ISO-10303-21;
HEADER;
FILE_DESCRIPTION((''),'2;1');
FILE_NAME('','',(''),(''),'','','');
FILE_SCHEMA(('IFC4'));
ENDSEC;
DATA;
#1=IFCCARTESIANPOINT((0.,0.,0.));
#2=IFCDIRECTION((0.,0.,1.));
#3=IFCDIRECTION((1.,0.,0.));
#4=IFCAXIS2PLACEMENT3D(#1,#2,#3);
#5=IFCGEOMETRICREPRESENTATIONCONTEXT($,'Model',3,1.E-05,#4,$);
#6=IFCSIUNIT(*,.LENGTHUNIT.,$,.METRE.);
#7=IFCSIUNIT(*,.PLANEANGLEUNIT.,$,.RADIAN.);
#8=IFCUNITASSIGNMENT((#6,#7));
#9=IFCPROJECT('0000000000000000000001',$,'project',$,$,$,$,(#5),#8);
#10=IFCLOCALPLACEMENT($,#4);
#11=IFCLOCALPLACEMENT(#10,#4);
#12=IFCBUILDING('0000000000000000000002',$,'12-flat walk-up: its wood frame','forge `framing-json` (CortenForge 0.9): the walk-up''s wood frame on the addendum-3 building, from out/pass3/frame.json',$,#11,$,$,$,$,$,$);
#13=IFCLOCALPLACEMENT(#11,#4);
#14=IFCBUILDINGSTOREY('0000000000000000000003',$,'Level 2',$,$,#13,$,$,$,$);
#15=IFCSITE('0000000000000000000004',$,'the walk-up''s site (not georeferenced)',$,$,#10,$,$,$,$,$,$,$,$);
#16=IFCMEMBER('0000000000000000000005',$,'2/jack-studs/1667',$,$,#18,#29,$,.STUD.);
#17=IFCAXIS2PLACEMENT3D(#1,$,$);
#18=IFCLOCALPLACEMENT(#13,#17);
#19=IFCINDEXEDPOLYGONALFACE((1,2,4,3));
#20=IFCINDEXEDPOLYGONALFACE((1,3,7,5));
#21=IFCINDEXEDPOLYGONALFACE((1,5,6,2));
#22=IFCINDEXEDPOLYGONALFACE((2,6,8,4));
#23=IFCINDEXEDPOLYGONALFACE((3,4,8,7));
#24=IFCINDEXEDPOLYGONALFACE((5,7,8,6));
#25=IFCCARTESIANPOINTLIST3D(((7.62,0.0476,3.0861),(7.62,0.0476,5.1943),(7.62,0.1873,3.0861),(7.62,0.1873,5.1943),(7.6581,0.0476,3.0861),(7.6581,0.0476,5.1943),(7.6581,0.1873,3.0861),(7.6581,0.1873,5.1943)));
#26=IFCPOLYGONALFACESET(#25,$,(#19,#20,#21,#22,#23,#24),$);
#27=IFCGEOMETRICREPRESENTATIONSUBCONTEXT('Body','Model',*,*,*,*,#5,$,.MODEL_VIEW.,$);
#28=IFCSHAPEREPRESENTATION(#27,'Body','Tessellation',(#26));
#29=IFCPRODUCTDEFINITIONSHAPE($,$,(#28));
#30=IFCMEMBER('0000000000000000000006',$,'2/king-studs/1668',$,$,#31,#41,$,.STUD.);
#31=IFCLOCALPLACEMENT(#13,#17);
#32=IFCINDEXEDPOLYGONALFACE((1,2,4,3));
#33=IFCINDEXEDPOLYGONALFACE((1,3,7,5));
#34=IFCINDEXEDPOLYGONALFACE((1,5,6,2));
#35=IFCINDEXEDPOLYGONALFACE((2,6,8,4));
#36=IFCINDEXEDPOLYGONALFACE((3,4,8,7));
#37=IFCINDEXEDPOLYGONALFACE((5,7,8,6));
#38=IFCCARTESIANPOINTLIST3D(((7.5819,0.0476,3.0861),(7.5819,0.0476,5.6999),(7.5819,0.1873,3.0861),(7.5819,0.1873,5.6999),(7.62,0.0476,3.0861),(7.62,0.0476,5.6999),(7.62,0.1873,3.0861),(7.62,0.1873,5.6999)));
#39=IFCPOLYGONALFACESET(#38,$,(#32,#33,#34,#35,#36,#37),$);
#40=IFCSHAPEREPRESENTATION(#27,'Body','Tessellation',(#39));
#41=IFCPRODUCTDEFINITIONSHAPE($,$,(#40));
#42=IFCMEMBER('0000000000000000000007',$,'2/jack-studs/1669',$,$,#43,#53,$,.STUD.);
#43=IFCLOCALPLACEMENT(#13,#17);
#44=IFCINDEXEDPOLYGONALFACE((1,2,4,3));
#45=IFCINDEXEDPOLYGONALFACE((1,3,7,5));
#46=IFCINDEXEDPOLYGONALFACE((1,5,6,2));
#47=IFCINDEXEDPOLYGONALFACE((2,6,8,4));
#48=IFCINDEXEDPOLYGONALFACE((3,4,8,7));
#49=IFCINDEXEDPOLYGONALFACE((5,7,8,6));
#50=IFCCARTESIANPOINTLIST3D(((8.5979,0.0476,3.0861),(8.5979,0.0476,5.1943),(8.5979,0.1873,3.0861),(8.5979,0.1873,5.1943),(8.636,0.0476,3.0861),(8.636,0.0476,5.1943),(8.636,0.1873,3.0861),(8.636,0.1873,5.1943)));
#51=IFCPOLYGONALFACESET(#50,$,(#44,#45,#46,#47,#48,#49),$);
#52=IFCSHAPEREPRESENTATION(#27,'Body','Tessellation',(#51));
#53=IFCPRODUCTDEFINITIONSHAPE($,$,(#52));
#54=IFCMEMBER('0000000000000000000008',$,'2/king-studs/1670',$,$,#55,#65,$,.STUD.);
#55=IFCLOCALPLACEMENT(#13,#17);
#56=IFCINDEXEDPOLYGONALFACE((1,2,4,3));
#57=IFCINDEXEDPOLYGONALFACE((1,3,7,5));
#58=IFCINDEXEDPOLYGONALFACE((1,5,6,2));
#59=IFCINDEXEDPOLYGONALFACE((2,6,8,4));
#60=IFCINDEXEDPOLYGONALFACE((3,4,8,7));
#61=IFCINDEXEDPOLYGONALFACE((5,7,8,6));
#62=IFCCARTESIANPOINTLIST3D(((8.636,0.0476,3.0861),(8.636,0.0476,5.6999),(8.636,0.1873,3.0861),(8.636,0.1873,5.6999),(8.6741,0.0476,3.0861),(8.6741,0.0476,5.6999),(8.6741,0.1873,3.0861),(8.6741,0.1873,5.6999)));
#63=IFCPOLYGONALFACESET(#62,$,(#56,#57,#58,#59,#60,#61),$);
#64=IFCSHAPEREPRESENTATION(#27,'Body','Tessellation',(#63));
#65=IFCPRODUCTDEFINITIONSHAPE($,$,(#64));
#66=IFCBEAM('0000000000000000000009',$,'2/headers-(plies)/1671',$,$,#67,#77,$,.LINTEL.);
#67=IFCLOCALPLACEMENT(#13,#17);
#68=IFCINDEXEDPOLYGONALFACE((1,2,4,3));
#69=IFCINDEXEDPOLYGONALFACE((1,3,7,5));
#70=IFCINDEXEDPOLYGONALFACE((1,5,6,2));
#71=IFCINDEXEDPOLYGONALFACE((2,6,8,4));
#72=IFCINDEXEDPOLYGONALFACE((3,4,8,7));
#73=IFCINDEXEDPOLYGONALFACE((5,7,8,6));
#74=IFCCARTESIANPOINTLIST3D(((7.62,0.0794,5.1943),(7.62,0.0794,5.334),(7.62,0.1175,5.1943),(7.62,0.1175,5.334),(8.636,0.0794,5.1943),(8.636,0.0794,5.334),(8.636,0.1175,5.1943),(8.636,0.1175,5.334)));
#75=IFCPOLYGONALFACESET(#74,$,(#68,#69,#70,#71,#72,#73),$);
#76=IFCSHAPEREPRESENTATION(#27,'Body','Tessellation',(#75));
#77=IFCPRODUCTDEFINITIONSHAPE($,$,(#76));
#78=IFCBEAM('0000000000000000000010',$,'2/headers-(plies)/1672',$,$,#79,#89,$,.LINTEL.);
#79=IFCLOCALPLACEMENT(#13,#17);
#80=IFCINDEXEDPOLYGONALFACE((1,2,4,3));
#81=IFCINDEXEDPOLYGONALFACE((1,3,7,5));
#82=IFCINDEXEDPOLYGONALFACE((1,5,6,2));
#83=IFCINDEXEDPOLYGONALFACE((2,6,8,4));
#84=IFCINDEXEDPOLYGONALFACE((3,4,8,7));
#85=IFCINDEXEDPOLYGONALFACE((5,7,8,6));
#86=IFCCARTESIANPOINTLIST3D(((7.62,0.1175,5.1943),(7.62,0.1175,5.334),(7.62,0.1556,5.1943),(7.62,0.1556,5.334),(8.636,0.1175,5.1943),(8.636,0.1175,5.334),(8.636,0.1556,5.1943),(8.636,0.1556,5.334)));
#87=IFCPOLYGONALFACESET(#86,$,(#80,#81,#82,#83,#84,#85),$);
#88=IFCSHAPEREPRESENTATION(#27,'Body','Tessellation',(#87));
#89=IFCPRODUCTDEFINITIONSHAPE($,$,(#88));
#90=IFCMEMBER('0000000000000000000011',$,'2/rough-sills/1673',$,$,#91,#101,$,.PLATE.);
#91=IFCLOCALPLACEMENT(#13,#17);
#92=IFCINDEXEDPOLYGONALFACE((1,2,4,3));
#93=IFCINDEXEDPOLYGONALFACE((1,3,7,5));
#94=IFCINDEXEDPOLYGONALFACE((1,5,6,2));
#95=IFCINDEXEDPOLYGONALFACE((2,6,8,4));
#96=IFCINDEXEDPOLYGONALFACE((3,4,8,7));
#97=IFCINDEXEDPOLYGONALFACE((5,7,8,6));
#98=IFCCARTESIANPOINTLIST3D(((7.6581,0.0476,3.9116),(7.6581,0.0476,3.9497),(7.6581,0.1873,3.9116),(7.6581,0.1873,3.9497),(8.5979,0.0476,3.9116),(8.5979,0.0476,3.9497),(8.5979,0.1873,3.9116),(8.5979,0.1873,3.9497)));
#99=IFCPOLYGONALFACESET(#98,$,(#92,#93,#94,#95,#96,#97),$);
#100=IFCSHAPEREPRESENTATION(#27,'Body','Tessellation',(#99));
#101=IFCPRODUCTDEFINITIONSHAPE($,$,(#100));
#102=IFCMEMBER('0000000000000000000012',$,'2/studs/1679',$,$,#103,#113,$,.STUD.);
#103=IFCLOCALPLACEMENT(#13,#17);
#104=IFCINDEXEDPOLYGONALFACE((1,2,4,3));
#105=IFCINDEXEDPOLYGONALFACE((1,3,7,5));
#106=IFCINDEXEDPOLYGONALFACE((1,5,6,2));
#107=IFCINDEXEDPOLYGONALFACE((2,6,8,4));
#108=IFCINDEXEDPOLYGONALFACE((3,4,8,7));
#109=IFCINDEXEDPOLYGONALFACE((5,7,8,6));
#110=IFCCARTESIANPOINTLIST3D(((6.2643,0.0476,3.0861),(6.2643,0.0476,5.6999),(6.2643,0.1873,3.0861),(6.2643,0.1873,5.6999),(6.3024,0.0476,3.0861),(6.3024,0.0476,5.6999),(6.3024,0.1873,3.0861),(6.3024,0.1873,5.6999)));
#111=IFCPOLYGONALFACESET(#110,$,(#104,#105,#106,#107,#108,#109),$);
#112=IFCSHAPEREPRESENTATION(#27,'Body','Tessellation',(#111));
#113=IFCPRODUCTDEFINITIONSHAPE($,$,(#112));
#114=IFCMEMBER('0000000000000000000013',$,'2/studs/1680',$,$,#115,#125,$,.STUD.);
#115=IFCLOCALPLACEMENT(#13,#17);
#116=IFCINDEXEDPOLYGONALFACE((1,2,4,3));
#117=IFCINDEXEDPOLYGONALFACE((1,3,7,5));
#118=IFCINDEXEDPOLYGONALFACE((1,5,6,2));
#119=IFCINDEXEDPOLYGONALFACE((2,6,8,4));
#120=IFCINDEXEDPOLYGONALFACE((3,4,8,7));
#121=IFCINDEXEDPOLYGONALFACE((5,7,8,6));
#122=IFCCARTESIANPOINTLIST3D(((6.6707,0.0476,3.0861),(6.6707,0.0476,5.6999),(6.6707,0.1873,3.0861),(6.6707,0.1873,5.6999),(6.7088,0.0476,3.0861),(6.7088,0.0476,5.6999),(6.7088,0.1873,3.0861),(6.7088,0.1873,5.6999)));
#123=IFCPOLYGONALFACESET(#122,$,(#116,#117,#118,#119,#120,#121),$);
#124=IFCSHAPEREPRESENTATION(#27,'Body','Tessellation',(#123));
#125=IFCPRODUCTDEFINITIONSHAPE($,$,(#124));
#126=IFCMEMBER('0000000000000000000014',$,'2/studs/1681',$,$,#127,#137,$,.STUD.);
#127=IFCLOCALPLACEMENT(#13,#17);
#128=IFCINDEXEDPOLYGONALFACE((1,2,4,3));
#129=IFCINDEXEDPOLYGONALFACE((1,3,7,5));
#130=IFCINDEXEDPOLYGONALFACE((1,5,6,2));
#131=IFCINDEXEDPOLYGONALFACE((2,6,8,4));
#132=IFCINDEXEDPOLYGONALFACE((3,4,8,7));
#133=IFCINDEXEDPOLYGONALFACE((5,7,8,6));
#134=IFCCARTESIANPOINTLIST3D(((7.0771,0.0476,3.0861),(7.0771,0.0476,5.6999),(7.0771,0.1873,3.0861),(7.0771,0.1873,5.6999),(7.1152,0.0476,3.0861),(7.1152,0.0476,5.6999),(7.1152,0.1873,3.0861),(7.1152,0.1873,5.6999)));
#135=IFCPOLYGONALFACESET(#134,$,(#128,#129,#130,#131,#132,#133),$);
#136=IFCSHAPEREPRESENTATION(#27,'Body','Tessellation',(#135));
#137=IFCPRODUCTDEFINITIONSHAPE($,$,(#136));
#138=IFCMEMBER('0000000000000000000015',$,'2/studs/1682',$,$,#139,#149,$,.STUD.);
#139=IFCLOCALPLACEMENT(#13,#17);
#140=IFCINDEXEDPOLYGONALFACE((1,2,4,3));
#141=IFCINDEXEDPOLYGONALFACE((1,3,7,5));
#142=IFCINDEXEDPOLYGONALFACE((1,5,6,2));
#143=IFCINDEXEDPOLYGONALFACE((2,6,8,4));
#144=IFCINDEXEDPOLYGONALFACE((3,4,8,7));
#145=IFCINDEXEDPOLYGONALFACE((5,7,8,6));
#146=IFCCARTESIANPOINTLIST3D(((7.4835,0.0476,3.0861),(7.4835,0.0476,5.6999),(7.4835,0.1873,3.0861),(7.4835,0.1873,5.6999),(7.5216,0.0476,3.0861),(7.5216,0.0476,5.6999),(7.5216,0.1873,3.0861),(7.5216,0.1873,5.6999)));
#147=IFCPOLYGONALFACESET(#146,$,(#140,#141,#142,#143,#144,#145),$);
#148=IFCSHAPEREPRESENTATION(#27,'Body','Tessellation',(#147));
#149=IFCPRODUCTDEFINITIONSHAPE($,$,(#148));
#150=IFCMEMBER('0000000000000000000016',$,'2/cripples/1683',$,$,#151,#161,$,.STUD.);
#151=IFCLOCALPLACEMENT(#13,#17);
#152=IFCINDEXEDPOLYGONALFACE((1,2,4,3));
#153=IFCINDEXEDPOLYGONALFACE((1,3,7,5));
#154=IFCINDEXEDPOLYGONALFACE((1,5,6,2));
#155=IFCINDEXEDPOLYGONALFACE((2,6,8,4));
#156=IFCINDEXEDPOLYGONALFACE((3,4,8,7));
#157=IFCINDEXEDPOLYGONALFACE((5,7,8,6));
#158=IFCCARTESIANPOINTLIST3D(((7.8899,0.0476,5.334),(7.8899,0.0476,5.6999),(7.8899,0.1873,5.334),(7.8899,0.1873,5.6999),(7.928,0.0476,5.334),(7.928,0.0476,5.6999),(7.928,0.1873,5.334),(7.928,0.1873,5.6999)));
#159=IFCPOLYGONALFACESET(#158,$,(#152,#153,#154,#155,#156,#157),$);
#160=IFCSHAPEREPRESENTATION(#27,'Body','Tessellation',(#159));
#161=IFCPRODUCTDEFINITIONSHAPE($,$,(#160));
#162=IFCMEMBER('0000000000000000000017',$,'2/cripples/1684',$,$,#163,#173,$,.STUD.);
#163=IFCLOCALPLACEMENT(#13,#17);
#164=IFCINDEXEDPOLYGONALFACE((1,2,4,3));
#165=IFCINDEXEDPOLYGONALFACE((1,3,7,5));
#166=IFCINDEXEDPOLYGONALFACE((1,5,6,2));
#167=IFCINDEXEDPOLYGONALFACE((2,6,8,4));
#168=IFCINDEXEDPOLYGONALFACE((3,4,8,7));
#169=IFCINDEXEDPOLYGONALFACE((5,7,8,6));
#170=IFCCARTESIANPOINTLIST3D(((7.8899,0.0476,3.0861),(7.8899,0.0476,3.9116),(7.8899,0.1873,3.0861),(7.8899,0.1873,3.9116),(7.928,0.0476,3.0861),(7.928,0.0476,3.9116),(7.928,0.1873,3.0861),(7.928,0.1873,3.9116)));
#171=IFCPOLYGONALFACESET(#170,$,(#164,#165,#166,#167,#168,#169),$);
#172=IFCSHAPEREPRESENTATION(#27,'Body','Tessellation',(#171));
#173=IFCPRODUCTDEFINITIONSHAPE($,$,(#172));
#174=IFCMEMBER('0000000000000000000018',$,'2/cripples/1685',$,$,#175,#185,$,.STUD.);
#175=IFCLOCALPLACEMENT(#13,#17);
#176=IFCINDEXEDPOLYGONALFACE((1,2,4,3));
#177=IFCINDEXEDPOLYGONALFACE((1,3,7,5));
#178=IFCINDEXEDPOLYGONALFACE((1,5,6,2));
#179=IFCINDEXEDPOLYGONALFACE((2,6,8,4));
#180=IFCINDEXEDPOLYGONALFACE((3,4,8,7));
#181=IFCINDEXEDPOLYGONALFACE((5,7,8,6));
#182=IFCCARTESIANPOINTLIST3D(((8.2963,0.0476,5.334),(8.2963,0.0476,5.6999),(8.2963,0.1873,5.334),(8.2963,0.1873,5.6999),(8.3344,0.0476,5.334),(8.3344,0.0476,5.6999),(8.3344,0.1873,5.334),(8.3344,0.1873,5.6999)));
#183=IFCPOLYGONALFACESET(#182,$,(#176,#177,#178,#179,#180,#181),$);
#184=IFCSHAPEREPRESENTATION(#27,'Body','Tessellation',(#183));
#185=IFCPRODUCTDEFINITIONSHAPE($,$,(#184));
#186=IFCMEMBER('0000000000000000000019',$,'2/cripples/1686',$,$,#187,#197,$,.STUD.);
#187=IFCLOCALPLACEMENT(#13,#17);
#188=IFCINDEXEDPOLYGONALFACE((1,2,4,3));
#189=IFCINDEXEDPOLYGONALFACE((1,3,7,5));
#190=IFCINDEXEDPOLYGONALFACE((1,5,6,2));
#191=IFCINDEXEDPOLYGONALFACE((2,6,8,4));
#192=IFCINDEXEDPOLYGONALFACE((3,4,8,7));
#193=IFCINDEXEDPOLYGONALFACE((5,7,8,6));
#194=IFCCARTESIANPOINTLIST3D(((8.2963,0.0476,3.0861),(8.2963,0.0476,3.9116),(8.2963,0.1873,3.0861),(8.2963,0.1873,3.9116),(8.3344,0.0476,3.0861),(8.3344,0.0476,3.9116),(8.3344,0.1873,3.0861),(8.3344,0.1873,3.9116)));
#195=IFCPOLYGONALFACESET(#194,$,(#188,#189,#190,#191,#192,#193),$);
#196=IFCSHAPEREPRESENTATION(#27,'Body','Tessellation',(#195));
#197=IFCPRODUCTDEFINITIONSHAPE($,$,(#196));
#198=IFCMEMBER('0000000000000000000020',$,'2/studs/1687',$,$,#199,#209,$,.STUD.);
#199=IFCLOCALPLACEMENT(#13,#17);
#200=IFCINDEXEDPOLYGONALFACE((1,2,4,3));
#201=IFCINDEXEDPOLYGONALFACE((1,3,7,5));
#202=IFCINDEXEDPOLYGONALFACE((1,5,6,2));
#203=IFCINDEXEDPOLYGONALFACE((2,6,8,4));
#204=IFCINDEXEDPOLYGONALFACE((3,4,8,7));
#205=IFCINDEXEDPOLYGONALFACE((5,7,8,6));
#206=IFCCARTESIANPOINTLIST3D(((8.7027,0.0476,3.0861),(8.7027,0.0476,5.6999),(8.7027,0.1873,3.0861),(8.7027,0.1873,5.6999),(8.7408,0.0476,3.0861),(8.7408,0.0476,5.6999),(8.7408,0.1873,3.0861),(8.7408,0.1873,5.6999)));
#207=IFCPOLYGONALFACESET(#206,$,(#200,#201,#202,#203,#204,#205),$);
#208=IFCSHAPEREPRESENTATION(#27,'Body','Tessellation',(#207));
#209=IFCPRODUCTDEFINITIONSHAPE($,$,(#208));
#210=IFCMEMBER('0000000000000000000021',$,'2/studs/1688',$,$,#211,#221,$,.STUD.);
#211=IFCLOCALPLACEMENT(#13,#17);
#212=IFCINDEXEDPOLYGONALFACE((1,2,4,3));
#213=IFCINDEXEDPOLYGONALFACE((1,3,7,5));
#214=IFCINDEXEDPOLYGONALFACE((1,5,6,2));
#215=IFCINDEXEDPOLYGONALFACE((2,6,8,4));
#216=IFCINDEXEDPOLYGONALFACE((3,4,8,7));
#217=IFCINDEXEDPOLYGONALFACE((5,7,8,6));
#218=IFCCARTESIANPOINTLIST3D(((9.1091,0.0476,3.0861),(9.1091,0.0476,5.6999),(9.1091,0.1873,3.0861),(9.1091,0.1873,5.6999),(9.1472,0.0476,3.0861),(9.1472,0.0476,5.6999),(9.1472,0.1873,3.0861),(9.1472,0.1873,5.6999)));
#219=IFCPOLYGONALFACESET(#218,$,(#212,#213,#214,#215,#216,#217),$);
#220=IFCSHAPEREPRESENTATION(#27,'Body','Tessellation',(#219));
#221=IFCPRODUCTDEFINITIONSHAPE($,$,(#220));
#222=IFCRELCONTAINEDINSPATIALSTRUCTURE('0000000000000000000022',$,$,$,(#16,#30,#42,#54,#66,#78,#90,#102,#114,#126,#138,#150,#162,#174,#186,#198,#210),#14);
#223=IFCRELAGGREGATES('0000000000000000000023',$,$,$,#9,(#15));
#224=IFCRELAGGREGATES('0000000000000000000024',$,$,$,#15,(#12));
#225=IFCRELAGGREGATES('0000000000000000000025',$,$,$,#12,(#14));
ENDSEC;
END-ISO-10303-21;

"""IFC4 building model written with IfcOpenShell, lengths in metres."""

from ifc_helpers import new_model, si_unit, frame, frame_2d, origin, origin_with_axes, place, context, subcontext, project, spatial, rectangle, extrude, element, save


model = new_model("IFC4")

# Units and contexts
model_context = context("Model", 3, precision=1e-05, world=origin_with_axes())
body_context = subcontext(model_context, "Body", "Model", "MODEL_VIEW")
ifc_project = project(units=[si_unit("LENGTHUNIT", "METRE"), si_unit("PLANEANGLEUNIT", "RADIAN")], contexts=[model_context])

# Site, building, storey
site_placement = place(None, origin_with_axes())
site = spatial("IfcSite", under=ifc_project, at=site_placement, Name="the walk-up's site (not georeferenced)")
building_placement = place(site_placement, origin_with_axes())
building = spatial("IfcBuilding", under=site, at=building_placement, Name="12-flat walk-up: its wood frame", Description="forge `framing-json` (CortenForge 0.9): the walk-up's wood frame on the addendum-3 building, from out/pass3/frame.json")
storey_placement = place(building_placement, origin_with_axes())
storey = spatial("IfcBuildingStorey", under=building, at=storey_placement, Name="Level 2")

# Members
member_1_placement = place(storey_placement, frame((7.62, 0.0476, 3.0861), z_axis=(0.0, 0.0, 1.0), x_axis=(1.0, 0.0, 0.0)))
element("IfcMember", 1, at=member_1_placement, inside=storey, Name="2/jack-studs/1667", PredefinedType="STUD", context=body_context, shape_type="SweptSolid", body=[
    extrude(rectangle(XDim=0.0381, YDim=0.1397, at=frame_2d((0.0191, 0.0698))), origin(), (0.0, 0.0, 1.0), 2.1082),
])
member_2_placement = place(storey_placement, frame((7.5819, 0.0476, 3.0861), z_axis=(0.0, 0.0, 1.0), x_axis=(1.0, 0.0, 0.0)))
element("IfcMember", 2, at=member_2_placement, inside=storey, Name="2/king-studs/1668", PredefinedType="STUD", context=body_context, shape_type="SweptSolid", body=[
    extrude(rectangle(XDim=0.0381, YDim=0.1397, at=frame_2d((0.0191, 0.0698))), origin(), (0.0, 0.0, 1.0), 2.6138),
])
member_3_placement = place(storey_placement, frame((8.5979, 0.0476, 3.0861), z_axis=(0.0, 0.0, 1.0), x_axis=(1.0, 0.0, 0.0)))
element("IfcMember", 3, at=member_3_placement, inside=storey, Name="2/jack-studs/1669", PredefinedType="STUD", context=body_context, shape_type="SweptSolid", body=[
    extrude(rectangle(XDim=0.0381, YDim=0.1397, at=frame_2d((0.0191, 0.0698))), origin(), (0.0, 0.0, 1.0), 2.1082),
])
member_4_placement = place(storey_placement, frame((8.636, 0.0476, 3.0861), z_axis=(0.0, 0.0, 1.0), x_axis=(1.0, 0.0, 0.0)))
element("IfcMember", 4, at=member_4_placement, inside=storey, Name="2/king-studs/1670", PredefinedType="STUD", context=body_context, shape_type="SweptSolid", body=[
    extrude(rectangle(XDim=0.0381, YDim=0.1397, at=frame_2d((0.0191, 0.0698))), origin(), (0.0, 0.0, 1.0), 2.6138),
])

# Beams
for number, where, z_axis, x_axis, name in (
    (5, (7.62, 0.0794, 5.1943), (0.0, 0.0, 1.0), (1.0, 0.0, 0.0), "2/headers-(plies)/1671"),
    (6, (7.62, 0.1175, 5.1943), (0.0, 0.0, 1.0), (1.0, 0.0, 0.0), "2/headers-(plies)/1672"),
):
    element("IfcBeam", number, at=place(storey_placement, frame(where, z_axis=z_axis, x_axis=x_axis)), inside=storey, Name=name, PredefinedType="LINTEL", context=body_context, shape_type="SweptSolid", body=[
        extrude(rectangle(XDim=1.016, YDim=0.0381, at=frame_2d((0.508, 0.019))), origin(), (0.0, 0.0, 1.0), 0.1397),
    ])

# Members
member_5_placement = place(storey_placement, frame((7.6581, 0.0476, 3.9116), z_axis=(0.0, 0.0, 1.0), x_axis=(1.0, 0.0, 0.0)))
element("IfcMember", 7, at=member_5_placement, inside=storey, Name="2/rough-sills/1673", PredefinedType="PLATE", context=body_context, shape_type="SweptSolid", body=[
    extrude(rectangle(XDim=0.9398, YDim=0.1397, at=frame_2d((0.4699, 0.0698))), origin(), (0.0, 0.0, 1.0), 0.0381),
])
for number, where, z_axis, x_axis, name in (
    (8, (6.2643, 0.0476, 3.0861), (0.0, 0.0, 1.0), (1.0, 0.0, 0.0), "2/studs/1679"),
    (9, (6.6707, 0.0476, 3.0861), (0.0, 0.0, 1.0), (1.0, 0.0, 0.0), "2/studs/1680"),
    (10, (7.0771, 0.0476, 3.0861), (0.0, 0.0, 1.0), (1.0, 0.0, 0.0), "2/studs/1681"),
    (11, (7.4835, 0.0476, 3.0861), (0.0, 0.0, 1.0), (1.0, 0.0, 0.0), "2/studs/1682"),
):
    element("IfcMember", number, at=place(storey_placement, frame(where, z_axis=z_axis, x_axis=x_axis)), inside=storey, Name=name, PredefinedType="STUD", context=body_context, shape_type="SweptSolid", body=[
        extrude(rectangle(XDim=0.0381, YDim=0.1397, at=frame_2d((0.0191, 0.0698))), origin(), (0.0, 0.0, 1.0), 2.6138),
    ])
member_6_placement = place(storey_placement, frame((7.8899, 0.0476, 5.334), z_axis=(0.0, 0.0, 1.0), x_axis=(1.0, 0.0, 0.0)))
element("IfcMember", 12, at=member_6_placement, inside=storey, Name="2/cripples/1683", PredefinedType="STUD", context=body_context, shape_type="SweptSolid", body=[
    extrude(rectangle(XDim=0.0381, YDim=0.1397, at=frame_2d((0.0191, 0.0698))), origin(), (0.0, 0.0, 1.0), 0.3659),
])
member_7_placement = place(storey_placement, frame((7.8899, 0.0476, 3.0861), z_axis=(0.0, 0.0, 1.0), x_axis=(1.0, 0.0, 0.0)))
element("IfcMember", 13, at=member_7_placement, inside=storey, Name="2/cripples/1684", PredefinedType="STUD", context=body_context, shape_type="SweptSolid", body=[
    extrude(rectangle(XDim=0.0381, YDim=0.1397, at=frame_2d((0.0191, 0.0698))), origin(), (0.0, 0.0, 1.0), 0.8255),
])
member_8_placement = place(storey_placement, frame((8.2963, 0.0476, 5.334), z_axis=(0.0, 0.0, 1.0), x_axis=(1.0, 0.0, 0.0)))
element("IfcMember", 14, at=member_8_placement, inside=storey, Name="2/cripples/1685", PredefinedType="STUD", context=body_context, shape_type="SweptSolid", body=[
    extrude(rectangle(XDim=0.0381, YDim=0.1397, at=frame_2d((0.0191, 0.0698))), origin(), (0.0, 0.0, 1.0), 0.3659),
])
member_9_placement = place(storey_placement, frame((8.2963, 0.0476, 3.0861), z_axis=(0.0, 0.0, 1.0), x_axis=(1.0, 0.0, 0.0)))
element("IfcMember", 15, at=member_9_placement, inside=storey, Name="2/cripples/1686", PredefinedType="STUD", context=body_context, shape_type="SweptSolid", body=[
    extrude(rectangle(XDim=0.0381, YDim=0.1397, at=frame_2d((0.0191, 0.0698))), origin(), (0.0, 0.0, 1.0), 0.8255),
])
for number, where, z_axis, x_axis, name in (
    (16, (8.7027, 0.0476, 3.0861), (0.0, 0.0, 1.0), (1.0, 0.0, 0.0), "2/studs/1687"),
    (17, (9.1091, 0.0476, 3.0861), (0.0, 0.0, 1.0), (1.0, 0.0, 0.0), "2/studs/1688"),
):
    element("IfcMember", number, at=place(storey_placement, frame(where, z_axis=z_axis, x_axis=x_axis)), inside=storey, Name=name, PredefinedType="STUD", context=body_context, shape_type="SweptSolid", body=[
        extrude(rectangle(XDim=0.0381, YDim=0.1397, at=frame_2d((0.0191, 0.0698))), origin(), (0.0, 0.0, 1.0), 2.6138),
    ])

save(model, "model.ifc")
